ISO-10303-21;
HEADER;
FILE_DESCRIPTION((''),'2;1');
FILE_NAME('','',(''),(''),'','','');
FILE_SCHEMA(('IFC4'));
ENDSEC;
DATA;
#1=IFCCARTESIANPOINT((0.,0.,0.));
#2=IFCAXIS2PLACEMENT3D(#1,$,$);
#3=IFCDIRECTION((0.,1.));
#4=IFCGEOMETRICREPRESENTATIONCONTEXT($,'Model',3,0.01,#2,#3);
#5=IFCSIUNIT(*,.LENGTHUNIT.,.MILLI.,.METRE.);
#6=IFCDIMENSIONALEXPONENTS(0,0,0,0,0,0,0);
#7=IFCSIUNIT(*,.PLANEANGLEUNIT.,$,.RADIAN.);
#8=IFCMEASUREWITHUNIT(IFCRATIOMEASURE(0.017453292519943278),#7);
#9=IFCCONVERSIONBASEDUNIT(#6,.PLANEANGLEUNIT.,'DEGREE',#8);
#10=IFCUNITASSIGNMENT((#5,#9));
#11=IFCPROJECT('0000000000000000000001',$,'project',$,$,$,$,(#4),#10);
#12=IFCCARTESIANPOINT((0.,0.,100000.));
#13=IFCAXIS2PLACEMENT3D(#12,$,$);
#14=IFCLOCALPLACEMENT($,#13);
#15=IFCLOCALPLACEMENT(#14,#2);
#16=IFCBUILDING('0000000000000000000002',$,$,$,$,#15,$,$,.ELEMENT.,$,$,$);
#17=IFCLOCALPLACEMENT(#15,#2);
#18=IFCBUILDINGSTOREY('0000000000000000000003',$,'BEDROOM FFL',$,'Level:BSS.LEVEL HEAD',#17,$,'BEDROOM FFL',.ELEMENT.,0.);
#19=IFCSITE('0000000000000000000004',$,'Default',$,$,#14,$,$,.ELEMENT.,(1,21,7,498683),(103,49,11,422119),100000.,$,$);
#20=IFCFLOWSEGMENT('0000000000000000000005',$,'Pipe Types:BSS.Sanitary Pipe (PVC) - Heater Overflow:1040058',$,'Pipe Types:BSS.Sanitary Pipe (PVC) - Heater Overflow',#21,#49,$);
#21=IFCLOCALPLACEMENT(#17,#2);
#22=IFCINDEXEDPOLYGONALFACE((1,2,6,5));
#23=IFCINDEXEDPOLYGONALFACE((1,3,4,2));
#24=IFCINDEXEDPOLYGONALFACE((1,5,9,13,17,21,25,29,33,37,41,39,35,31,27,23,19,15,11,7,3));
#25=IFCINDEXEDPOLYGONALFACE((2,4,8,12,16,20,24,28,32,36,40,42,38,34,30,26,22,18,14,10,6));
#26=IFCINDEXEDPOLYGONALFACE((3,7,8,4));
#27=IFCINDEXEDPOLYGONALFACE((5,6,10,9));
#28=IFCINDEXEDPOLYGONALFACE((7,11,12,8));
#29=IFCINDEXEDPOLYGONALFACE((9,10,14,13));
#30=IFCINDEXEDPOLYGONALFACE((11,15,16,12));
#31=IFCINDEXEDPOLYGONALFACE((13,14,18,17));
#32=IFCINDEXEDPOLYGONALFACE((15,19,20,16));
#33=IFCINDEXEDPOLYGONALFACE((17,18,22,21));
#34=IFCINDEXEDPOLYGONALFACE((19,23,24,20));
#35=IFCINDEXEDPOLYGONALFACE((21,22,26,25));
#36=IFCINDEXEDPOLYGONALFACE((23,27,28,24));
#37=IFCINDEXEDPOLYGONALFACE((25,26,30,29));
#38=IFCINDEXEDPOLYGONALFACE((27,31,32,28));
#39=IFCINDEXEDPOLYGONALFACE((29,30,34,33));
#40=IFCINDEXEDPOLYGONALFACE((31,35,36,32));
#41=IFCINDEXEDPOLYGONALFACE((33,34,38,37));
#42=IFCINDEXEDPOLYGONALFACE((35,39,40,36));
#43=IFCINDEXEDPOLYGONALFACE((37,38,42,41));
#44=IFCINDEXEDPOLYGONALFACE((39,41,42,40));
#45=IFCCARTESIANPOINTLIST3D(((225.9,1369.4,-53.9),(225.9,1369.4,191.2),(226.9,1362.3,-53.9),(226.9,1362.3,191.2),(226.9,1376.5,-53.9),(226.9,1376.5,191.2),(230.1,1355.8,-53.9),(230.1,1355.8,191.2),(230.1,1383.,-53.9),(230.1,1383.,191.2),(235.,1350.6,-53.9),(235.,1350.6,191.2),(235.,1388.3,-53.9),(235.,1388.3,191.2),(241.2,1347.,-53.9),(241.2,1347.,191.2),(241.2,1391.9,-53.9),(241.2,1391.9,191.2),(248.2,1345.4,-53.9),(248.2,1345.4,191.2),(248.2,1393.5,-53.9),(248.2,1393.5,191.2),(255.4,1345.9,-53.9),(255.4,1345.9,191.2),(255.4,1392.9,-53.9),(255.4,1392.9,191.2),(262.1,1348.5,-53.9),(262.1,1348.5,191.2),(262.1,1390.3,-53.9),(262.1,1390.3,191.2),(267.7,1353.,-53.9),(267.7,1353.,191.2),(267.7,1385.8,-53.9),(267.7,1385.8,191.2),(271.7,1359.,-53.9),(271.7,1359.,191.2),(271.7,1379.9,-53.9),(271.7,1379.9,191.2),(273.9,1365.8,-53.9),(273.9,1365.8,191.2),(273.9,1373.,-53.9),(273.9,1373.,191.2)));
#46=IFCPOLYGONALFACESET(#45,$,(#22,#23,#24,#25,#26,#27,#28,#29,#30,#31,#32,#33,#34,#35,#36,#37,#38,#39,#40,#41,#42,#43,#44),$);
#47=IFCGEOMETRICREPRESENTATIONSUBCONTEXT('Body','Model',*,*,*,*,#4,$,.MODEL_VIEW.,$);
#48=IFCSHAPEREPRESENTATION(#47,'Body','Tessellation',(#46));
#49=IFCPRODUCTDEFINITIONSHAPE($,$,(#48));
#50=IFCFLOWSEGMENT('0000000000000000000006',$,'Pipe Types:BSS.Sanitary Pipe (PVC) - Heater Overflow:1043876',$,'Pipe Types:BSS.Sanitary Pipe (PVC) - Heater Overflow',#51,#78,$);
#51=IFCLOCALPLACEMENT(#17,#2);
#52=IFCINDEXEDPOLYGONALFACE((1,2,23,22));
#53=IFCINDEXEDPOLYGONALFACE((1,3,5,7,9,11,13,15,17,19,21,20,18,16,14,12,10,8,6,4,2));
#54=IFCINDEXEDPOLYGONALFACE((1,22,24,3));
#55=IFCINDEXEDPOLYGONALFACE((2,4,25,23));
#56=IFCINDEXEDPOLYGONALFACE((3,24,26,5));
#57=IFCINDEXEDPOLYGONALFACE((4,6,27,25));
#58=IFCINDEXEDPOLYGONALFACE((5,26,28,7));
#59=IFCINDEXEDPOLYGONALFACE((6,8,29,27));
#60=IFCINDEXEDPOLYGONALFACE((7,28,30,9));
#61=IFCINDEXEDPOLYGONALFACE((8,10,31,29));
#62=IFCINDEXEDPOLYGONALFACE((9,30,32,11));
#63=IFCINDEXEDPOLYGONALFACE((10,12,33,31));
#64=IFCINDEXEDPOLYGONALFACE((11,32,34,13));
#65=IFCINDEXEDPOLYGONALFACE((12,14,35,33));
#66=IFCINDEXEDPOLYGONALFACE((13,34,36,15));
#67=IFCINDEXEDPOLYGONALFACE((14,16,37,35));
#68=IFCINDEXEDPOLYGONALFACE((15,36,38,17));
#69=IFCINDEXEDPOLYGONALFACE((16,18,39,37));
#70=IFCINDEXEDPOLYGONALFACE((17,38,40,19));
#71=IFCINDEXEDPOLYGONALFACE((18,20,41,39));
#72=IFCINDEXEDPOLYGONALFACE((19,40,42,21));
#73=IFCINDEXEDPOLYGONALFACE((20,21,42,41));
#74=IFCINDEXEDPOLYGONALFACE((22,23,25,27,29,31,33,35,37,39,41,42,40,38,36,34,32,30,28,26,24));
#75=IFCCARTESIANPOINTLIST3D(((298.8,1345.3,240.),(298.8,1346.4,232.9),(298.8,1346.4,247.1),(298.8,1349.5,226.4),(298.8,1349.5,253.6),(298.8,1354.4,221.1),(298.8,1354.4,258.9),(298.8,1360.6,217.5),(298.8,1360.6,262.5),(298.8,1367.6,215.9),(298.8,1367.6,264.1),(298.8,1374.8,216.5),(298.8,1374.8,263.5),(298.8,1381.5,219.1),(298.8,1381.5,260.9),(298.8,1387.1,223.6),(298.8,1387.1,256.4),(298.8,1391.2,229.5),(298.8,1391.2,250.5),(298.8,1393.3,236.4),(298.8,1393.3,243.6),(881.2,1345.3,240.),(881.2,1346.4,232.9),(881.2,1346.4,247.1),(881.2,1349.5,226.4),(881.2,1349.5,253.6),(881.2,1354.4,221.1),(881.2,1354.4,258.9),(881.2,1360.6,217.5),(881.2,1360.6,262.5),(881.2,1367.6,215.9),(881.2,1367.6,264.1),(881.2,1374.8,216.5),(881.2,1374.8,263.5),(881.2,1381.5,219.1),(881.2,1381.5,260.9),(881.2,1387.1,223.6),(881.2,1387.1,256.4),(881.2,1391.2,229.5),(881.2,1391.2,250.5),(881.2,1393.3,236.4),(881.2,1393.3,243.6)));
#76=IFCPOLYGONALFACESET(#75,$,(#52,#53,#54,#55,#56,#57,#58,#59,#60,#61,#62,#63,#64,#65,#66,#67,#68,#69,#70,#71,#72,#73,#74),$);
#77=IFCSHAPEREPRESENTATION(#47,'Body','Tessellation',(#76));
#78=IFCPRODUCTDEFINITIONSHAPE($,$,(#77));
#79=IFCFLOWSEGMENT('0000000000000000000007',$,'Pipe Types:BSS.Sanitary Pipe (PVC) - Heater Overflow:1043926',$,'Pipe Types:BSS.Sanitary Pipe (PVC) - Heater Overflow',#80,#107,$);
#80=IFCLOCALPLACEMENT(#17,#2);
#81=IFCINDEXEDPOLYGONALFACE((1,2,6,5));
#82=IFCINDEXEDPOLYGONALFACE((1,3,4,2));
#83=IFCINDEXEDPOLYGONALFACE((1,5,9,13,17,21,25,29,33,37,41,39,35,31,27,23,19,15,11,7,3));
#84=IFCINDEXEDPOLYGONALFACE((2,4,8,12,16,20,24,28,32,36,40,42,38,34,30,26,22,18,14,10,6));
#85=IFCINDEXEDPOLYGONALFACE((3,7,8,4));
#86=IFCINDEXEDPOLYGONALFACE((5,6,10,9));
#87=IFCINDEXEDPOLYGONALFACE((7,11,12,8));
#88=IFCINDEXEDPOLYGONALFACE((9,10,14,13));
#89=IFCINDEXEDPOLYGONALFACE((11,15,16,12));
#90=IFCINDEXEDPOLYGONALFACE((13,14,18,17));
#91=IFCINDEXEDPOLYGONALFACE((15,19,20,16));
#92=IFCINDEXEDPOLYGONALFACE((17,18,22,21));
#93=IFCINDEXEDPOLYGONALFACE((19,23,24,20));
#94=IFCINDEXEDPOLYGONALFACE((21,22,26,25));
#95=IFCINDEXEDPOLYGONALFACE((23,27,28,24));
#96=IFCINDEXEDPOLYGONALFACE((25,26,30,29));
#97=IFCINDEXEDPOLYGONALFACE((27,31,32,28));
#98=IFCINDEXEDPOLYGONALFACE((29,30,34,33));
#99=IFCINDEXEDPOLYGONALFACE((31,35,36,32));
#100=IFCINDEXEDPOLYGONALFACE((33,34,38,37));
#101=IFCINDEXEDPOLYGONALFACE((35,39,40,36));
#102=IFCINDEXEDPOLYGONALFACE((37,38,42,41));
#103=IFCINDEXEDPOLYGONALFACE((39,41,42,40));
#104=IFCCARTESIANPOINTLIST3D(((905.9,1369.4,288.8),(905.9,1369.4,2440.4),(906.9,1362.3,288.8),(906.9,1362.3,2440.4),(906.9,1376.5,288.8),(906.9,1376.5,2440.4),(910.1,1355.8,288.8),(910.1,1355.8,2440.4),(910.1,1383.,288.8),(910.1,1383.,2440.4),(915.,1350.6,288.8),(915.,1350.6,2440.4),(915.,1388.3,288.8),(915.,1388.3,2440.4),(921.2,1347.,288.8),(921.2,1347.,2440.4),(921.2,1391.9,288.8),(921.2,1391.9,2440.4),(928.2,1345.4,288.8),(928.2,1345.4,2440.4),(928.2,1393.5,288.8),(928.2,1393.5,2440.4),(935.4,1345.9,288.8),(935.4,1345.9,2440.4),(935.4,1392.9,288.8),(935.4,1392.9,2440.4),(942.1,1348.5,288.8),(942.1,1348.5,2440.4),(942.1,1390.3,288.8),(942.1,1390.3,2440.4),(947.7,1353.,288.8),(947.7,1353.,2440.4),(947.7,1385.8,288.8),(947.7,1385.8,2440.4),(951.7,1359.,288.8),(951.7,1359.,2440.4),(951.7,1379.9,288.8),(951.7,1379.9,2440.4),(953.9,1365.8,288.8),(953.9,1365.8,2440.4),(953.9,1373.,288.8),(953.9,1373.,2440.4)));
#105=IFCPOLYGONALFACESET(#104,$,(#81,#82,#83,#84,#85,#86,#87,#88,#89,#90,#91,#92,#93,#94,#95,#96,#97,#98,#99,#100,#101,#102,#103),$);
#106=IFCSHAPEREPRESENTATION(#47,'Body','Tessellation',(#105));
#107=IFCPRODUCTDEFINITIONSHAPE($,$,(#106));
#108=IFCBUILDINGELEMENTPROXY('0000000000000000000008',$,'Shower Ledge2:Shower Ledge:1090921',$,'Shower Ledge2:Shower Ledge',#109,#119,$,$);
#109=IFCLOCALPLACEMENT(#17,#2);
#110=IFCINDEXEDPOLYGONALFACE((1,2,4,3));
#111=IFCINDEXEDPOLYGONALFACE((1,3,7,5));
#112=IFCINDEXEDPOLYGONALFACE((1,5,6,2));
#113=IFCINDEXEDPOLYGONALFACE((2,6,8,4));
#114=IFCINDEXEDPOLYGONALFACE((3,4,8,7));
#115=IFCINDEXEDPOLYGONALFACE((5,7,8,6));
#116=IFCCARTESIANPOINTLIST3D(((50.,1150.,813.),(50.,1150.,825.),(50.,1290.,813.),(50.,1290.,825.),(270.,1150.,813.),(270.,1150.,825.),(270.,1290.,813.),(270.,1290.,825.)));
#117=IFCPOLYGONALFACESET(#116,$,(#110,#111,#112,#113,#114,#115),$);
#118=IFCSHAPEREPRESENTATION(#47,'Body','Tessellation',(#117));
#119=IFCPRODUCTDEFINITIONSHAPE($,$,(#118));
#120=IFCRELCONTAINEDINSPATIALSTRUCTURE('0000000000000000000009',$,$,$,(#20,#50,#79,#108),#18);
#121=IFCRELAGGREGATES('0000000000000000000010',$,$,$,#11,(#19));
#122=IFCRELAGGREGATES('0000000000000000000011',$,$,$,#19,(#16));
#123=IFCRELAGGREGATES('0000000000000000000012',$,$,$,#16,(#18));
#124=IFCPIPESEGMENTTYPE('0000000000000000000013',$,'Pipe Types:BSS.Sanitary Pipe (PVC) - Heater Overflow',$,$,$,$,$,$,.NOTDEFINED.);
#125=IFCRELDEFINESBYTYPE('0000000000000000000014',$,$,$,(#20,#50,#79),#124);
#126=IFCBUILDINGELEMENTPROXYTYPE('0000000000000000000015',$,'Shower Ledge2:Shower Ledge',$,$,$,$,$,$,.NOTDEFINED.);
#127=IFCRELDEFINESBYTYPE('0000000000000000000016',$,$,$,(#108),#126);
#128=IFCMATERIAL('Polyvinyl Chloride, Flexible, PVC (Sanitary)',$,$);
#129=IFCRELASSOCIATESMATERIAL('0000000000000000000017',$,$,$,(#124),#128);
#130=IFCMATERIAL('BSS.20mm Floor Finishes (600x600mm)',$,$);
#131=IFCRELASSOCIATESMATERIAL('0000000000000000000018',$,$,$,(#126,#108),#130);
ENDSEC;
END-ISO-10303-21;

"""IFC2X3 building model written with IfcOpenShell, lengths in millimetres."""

from ifc_helpers import new_model, entity, si_unit, converted_unit, direction, frame, frame_2d, origin, origin_2d_with_axis, place, context, subcontext, project, spatial, rectangle, circle, extrude, source, transform, mapped, material, type_object, type_shapes, element, save


model = new_model("IFC2X3")

# Units and contexts
model_context = context("Model", 3, precision=0.01, world=origin(), true_north=direction((0.0, 1.0)))
body_context = subcontext(model_context, "Body", "Model", "MODEL_VIEW")
ifc_project = project(units=[si_unit("LENGTHUNIT", "METRE", prefix="MILLI"), converted_unit("PLANEANGLEUNIT", "DEGREE", entity("IfcRatioMeasure", 0.017453292519943278), si_unit("PLANEANGLEUNIT", "RADIAN"), dimensions=[0, 0, 0, 0, 0, 0, 0])], contexts=[model_context])

# Site, building, storey
site_placement = place(None, frame((0.0, 0.0, 100000.0)))
site = spatial("IfcSite", under=ifc_project, at=site_placement, Name="Default", CompositionType="ELEMENT", RefLatitude=(1, 21, 7, 498683), RefLongitude=(103, 49, 11, 422119), RefElevation=100000.0)
building_placement = place(site_placement, origin())
building = spatial("IfcBuilding", under=site, at=building_placement, CompositionType="ELEMENT")
storey_placement = place(building_placement, origin())
storey = spatial("IfcBuildingStorey", under=building, at=storey_placement, Name="BEDROOM FFL", ObjectType="Level:BSS.LEVEL HEAD", LongName="BEDROOM FFL", CompositionType="ELEMENT", Elevation=0.0)

# Shared definitions
ifc_material_1 = material(Name="BSS.20mm Floor Finishes (600x600mm)")

# Flow segments
ifc_material_2 = material(Name="Polyvinyl Chloride, Flexible, PVC (Sanitary)")
pipe_segment_type = type_object("IfcPipeSegmentType", Name="Pipe Types:BSS.Sanitary Pipe (PVC) - Heater Overflow", PredefinedType="NOTDEFINED", material=ifc_material_2)
flow_segment_1_placement = place(storey_placement, origin())
element("IfcFlowSegment", 1, at=flow_segment_1_placement, inside=storey, type_object=pipe_segment_type, Name="Pipe Types:BSS.Sanitary Pipe (PVC) - Heater Overflow:1040058", ObjectType="Pipe Types:BSS.Sanitary Pipe (PVC) - Heater Overflow", context=body_context, shape_type="SweptSolid", body=[
    extrude(circle(Radius=24.1, at=frame_2d((0.0, 0.0), x_axis=(1.0, 0.0))), frame((250.0, 1369.4, -53.9), z_axis=(0.0, 0.0, 1.0), x_axis=(-1.0, 0.0, 0.0)), (0.0, 0.0, 1.0), 245.1),
])
flow_segment_2_placement = place(storey_placement, origin())
element("IfcFlowSegment", 2, at=flow_segment_2_placement, inside=storey, type_object=pipe_segment_type, Name="Pipe Types:BSS.Sanitary Pipe (PVC) - Heater Overflow:1043876", ObjectType="Pipe Types:BSS.Sanitary Pipe (PVC) - Heater Overflow", context=body_context, shape_type="SweptSolid", body=[
    extrude(circle(Radius=24.1, at=frame_2d((0.0, 0.0), x_axis=(1.0, 0.0))), frame((298.8, 1369.4, 240.0), z_axis=(1.0, 0.0, 0.0), x_axis=(0.0, -1.0, 0.0)), (0.0, 0.0, 1.0), 582.5),
])
flow_segment_3_placement = place(storey_placement, origin())
element("IfcFlowSegment", 3, at=flow_segment_3_placement, inside=storey, type_object=pipe_segment_type, Name="Pipe Types:BSS.Sanitary Pipe (PVC) - Heater Overflow:1043926", ObjectType="Pipe Types:BSS.Sanitary Pipe (PVC) - Heater Overflow", context=body_context, shape_type="SweptSolid", body=[
    extrude(circle(Radius=24.1, at=frame_2d((0.0, 0.0), x_axis=(1.0, 0.0))), frame((930.0, 1369.4, 288.8), z_axis=(0.0, 0.0, 1.0), x_axis=(-1.0, 0.0, 0.0)), (0.0, 0.0, 1.0), 2151.6),
])

# Building element proxy
building_element_proxy_type = type_object("IfcBuildingElementProxyType", Name="Shower Ledge2:Shower Ledge", PredefinedType="NOTDEFINED", material=ifc_material_1)
shared_shape = source(origin(), body_context, "Body", "SweptSolid", [
    extrude(rectangle(XDim=220.0, YDim=140.0, at=origin_2d_with_axis()), frame((160.0, 1220.0, 813.0), z_axis=(0.0, 0.0, 1.0), x_axis=(-1.0, 0.0, 0.0)), (0.0, 0.0, 1.0), 12.0),
])
type_shapes(building_element_proxy_type, [shared_shape])
proxy_placement = place(storey_placement, origin())
element("IfcBuildingElementProxy", 4, at=proxy_placement, inside=storey, type_object=building_element_proxy_type, material=ifc_material_1, Name="Shower Ledge2:Shower Ledge:1090921", ObjectType="Shower Ledge2:Shower Ledge", context=body_context, shape_type="MappedRepresentation", body=[
    mapped(shared_shape, transform((0.0, 0.0, 0.0), scale=1.0)),
])

save(model, "model.ifc")
